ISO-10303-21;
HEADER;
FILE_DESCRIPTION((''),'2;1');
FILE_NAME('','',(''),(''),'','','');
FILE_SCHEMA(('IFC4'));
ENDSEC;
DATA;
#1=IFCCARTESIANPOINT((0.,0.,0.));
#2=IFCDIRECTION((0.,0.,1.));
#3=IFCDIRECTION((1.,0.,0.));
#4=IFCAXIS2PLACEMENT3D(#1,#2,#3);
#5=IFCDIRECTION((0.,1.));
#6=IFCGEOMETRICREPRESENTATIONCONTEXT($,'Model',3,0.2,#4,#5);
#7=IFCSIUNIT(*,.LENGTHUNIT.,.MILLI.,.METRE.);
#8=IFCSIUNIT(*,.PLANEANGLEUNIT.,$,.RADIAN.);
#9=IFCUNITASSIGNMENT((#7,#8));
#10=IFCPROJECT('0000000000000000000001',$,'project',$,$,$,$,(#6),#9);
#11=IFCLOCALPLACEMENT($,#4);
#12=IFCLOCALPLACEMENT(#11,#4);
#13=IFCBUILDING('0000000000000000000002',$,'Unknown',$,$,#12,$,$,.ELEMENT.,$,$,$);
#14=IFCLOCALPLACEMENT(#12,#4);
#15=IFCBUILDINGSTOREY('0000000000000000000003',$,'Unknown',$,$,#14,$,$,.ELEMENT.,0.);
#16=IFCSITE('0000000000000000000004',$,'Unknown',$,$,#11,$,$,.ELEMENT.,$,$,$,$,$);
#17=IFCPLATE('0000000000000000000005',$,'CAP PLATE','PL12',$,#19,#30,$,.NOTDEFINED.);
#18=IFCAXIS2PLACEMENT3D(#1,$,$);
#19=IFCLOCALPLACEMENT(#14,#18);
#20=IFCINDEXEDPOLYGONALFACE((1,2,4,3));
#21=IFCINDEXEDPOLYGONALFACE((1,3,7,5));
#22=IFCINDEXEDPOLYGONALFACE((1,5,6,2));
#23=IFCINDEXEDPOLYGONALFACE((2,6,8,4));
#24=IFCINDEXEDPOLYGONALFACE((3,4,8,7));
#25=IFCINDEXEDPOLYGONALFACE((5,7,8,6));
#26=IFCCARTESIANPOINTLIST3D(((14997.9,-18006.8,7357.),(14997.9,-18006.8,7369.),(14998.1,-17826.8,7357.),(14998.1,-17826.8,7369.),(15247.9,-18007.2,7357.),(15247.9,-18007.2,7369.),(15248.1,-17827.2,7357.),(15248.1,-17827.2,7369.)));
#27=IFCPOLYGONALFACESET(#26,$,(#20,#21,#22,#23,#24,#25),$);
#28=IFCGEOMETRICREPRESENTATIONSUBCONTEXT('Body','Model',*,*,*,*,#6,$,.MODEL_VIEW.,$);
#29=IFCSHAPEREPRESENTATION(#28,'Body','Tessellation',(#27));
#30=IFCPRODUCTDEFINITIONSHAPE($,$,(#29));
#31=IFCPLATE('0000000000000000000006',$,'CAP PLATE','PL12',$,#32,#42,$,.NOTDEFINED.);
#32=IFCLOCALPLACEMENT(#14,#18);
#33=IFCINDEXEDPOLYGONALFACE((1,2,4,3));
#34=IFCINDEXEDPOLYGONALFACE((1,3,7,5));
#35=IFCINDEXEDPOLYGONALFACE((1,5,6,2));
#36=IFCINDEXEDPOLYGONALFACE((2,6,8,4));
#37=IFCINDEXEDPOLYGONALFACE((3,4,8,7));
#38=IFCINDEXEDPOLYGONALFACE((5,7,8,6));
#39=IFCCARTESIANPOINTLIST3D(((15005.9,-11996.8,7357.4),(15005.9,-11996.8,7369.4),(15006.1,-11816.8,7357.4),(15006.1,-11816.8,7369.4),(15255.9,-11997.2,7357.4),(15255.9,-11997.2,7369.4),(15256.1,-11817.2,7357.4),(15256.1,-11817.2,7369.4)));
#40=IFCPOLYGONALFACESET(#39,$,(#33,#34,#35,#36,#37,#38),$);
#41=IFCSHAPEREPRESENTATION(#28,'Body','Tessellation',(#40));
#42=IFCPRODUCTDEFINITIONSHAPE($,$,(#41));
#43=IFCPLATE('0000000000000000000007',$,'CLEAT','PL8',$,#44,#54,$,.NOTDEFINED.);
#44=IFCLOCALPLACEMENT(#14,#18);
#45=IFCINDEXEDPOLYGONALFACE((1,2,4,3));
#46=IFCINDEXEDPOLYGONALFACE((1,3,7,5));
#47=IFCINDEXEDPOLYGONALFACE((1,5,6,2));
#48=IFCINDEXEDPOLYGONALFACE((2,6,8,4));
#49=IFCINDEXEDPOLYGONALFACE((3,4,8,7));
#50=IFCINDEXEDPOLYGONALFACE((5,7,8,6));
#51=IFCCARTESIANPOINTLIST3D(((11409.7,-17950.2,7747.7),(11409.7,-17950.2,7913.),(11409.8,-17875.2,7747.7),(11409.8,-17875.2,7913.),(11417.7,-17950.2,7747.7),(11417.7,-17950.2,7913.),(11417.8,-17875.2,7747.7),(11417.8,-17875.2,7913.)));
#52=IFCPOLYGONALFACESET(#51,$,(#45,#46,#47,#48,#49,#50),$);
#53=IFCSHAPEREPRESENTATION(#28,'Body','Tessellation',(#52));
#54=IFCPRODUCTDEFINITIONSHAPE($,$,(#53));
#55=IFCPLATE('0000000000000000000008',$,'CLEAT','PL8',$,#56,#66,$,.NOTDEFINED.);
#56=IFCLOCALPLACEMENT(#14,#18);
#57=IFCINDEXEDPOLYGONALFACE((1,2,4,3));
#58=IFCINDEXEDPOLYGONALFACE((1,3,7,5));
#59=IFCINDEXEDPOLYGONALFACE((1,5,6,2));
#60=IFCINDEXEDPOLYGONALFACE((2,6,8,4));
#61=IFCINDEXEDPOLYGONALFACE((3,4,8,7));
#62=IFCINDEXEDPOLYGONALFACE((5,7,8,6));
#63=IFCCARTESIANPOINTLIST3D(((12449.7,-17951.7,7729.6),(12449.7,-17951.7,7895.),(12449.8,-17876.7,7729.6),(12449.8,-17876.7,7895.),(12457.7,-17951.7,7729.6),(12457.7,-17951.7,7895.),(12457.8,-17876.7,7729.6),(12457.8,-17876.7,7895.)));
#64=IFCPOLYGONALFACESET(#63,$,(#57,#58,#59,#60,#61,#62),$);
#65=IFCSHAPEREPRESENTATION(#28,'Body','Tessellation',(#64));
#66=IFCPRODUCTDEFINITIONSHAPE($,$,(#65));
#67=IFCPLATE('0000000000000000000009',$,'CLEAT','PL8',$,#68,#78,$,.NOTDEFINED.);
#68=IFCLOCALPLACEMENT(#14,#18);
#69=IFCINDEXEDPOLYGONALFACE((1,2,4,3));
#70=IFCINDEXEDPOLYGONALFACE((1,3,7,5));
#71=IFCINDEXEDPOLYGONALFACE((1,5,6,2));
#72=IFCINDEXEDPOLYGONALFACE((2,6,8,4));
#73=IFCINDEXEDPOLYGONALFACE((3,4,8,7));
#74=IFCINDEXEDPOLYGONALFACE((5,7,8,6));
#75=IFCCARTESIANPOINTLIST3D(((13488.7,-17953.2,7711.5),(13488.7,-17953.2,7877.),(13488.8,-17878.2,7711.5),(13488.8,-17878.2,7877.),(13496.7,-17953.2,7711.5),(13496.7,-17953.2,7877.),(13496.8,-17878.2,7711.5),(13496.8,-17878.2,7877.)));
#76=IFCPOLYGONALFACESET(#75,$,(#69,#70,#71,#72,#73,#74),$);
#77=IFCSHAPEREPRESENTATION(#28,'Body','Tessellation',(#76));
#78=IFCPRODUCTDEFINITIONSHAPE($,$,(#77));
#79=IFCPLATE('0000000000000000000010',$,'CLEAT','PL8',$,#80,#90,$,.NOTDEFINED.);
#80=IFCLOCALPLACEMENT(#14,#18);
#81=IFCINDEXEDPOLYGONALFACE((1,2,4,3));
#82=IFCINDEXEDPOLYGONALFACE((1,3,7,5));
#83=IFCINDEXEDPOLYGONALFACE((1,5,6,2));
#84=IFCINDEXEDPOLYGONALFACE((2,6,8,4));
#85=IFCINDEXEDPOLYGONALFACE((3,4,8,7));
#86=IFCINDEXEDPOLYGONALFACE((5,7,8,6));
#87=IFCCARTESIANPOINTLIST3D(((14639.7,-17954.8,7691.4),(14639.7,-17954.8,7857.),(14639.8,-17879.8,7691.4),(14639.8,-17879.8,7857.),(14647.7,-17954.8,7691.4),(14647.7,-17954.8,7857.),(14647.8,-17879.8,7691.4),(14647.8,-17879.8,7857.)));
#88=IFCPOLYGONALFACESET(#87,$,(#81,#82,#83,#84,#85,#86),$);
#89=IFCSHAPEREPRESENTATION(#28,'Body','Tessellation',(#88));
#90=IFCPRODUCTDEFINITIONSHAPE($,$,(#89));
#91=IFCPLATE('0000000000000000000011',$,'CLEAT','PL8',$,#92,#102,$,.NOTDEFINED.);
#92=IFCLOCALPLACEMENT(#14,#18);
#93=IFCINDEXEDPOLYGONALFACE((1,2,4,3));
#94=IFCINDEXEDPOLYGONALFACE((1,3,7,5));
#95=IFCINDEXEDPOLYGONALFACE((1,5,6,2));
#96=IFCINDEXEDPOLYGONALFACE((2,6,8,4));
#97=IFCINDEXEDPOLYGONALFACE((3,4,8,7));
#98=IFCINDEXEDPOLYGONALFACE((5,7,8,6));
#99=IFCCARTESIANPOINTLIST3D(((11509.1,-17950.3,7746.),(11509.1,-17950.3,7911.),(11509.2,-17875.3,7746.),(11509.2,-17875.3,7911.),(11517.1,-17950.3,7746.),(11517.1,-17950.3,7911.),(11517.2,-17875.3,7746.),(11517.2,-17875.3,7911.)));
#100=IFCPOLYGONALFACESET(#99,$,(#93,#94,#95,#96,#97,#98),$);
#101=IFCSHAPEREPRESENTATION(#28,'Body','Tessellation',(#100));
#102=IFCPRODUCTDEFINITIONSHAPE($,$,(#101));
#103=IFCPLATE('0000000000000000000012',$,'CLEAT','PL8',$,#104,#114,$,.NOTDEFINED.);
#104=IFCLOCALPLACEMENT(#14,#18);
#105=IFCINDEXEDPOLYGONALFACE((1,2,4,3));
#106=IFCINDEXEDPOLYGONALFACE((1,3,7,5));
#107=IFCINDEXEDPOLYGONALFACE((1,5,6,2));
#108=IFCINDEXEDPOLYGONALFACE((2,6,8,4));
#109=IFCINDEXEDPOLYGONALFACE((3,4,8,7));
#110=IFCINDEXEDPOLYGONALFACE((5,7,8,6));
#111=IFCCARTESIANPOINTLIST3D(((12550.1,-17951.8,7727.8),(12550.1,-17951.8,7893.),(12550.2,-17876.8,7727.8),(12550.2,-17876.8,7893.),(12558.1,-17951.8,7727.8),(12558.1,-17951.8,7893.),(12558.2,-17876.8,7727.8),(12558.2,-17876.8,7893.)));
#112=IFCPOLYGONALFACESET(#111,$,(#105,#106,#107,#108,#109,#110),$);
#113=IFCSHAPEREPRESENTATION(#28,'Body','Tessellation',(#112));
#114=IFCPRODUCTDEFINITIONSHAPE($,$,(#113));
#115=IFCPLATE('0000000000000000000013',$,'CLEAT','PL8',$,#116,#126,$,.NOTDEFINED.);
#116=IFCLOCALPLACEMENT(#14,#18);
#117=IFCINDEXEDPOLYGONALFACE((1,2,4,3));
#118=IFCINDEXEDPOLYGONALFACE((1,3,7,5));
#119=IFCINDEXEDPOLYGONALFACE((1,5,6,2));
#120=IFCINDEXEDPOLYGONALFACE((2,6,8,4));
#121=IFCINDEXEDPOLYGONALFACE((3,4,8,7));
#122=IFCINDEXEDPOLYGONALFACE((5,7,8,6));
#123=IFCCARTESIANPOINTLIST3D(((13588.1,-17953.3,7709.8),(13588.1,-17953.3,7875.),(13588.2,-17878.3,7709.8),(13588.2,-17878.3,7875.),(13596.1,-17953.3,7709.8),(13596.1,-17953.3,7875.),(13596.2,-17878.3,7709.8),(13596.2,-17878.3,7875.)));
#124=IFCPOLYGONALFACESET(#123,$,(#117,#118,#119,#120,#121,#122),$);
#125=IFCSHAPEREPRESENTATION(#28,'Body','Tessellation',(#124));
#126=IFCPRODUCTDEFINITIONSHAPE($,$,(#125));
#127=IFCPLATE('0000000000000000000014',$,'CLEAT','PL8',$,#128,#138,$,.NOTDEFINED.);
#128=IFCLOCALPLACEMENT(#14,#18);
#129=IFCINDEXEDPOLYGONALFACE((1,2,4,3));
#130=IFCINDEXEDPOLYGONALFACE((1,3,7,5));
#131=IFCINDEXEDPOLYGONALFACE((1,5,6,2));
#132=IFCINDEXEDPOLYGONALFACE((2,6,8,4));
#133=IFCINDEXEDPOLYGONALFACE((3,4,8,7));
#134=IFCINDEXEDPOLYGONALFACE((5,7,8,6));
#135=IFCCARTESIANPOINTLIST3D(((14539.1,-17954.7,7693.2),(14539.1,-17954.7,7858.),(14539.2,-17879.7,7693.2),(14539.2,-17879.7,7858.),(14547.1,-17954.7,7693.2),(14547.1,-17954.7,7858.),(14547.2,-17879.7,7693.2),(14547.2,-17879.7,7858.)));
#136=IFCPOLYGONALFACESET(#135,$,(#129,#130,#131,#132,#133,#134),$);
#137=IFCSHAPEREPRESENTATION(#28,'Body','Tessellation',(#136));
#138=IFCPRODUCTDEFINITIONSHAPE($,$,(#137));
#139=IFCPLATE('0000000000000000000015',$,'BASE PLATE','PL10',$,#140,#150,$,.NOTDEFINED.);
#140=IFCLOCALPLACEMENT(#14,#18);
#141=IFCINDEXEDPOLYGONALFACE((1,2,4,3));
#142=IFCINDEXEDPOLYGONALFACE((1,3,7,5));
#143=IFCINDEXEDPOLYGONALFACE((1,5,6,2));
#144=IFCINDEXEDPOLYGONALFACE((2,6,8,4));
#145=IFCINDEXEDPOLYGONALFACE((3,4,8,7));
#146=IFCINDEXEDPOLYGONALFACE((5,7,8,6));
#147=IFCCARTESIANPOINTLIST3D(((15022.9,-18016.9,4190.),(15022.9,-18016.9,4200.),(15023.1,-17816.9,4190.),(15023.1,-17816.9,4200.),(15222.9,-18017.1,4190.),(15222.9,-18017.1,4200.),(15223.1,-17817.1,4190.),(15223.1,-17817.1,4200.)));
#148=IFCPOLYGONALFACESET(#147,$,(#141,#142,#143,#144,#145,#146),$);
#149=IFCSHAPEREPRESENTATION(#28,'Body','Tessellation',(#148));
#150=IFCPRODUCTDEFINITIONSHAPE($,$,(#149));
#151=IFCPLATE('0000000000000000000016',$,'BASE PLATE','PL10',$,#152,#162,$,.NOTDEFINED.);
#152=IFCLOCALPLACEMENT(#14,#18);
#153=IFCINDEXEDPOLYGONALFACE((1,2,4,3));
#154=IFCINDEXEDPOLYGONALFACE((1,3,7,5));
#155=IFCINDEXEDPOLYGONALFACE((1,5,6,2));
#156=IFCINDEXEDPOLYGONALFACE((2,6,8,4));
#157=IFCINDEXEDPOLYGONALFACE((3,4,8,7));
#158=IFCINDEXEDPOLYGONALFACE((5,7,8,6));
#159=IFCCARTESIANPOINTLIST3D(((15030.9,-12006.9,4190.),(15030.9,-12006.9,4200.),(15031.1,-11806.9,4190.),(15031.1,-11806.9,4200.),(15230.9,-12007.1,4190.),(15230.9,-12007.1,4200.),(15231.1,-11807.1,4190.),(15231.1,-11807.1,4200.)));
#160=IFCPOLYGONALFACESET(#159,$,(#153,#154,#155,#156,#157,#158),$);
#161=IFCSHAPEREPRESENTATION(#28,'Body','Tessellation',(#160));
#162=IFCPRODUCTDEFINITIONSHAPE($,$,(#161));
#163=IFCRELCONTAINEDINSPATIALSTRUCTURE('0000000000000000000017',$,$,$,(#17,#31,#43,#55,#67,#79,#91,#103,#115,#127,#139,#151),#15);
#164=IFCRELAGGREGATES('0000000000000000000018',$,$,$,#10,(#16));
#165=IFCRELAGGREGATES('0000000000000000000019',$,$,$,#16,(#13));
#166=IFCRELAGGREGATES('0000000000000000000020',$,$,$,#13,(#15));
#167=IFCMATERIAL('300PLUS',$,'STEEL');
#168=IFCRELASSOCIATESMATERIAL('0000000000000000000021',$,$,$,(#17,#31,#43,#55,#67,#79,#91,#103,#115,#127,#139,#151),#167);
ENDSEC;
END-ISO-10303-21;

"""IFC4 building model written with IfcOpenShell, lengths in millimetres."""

from ifc_helpers import new_model, si_unit, direction, frame, origin_with_axes, place, context, subcontext, project, spatial, line, indexed_curve, outline, extrude, material, element, save


model = new_model("IFC4")

# Units and contexts
model_context = context("Model", 3, precision=0.2, world=origin_with_axes(), true_north=direction((0.0, 1.0)))
body_context = subcontext(model_context, "Body", "Model", "MODEL_VIEW")
ifc_project = project(units=[si_unit("LENGTHUNIT", "METRE", prefix="MILLI"), si_unit("PLANEANGLEUNIT", "RADIAN")], contexts=[model_context])

# Site, building, storey
site_placement = place(None, origin_with_axes())
site = spatial("IfcSite", under=ifc_project, at=site_placement, Name="Unknown", CompositionType="ELEMENT")
building_placement = place(site_placement, origin_with_axes())
building = spatial("IfcBuilding", under=site, at=building_placement, Name="Unknown", CompositionType="ELEMENT")
storey_placement = place(building_placement, origin_with_axes())
storey = spatial("IfcBuildingStorey", under=building, at=storey_placement, Name="Unknown", CompositionType="ELEMENT", Elevation=0.0)

# Shared definitions
ifc_material_1 = material(Name="300PLUS", Category="STEEL")

# Plates
for number, where, z_axis, x_axis, name in (
    (1, (14997.9, -18006.8, 7363.0), (0.0, 0.0, 1.0), (0.999999, -0.0016, 0.0), "CAP PLATE"),
    (2, (15005.9, -11996.8, 7363.4), (0.0, 0.0, 1.0), (0.999999, -0.0016, 0.0), "CAP PLATE"),
):
    element("IfcPlate", number, at=place(storey_placement, frame(where, z_axis=z_axis, x_axis=x_axis)), inside=storey, material=ifc_material_1, Name=name, Description="PL12", PredefinedType="NOTDEFINED", context=body_context, shape_type="SolidModel", body=[
        extrude(outline(indexed_curve([(0.0, 0.0), (250.0, 0.0), (249.9, 180.0), (-0.1, 180.0)], segments=[line(1, 2, 3, 4, 1)])), frame((0.0, 0.0, 6.0), z_axis=(0.0, 0.0, 1.0), x_axis=(1.0, 0.0, 0.0)), (0.0, 0.0, -1.0), 12.0),
    ])
plate_1_placement = place(storey_placement, frame((11413.8, -17875.2, 7913.0), z_axis=(0.999999, -0.001333, 0.0), x_axis=(-0.001333, -0.999999, 0.0)))
element("IfcPlate", 3, at=plate_1_placement, inside=storey, material=ifc_material_1, Name="CLEAT", Description="PL8", PredefinedType="NOTDEFINED", context=body_context, shape_type="SolidModel", body=[
    extrude(outline(indexed_curve([(0.0, 0.0), (75.0, 0.0), (75.0, 165.3), (0.0, 165.3)], segments=[line(1, 2, 3, 4, 1)])), frame((0.0, 0.0, 4.0), z_axis=(0.0, 0.0, 1.0), x_axis=(1.0, 0.0, 0.0)), (0.0, 0.0, -1.0), 8.0),
])
plate_2_placement = place(storey_placement, frame((12453.8, -17876.7, 7895.0), z_axis=(0.999999, -0.001333, 0.0), x_axis=(-0.001333, -0.999999, 0.0)))
element("IfcPlate", 4, at=plate_2_placement, inside=storey, material=ifc_material_1, Name="CLEAT", Description="PL8", PredefinedType="NOTDEFINED", context=body_context, shape_type="SolidModel", body=[
    extrude(outline(indexed_curve([(0.0, 0.0), (75.0, 0.0), (75.0, 165.4), (0.0, 165.4)], segments=[line(1, 2, 3, 4, 1)])), frame((0.0, 0.0, 4.0), z_axis=(0.0, 0.0, 1.0), x_axis=(1.0, 0.0, 0.0)), (0.0, 0.0, -1.0), 8.0),
])
plate_3_placement = place(storey_placement, frame((13492.8, -17878.2, 7877.0), z_axis=(0.999999, -0.001333, 0.0), x_axis=(-0.001333, -0.999999, 0.0)))
element("IfcPlate", 5, at=plate_3_placement, inside=storey, material=ifc_material_1, Name="CLEAT", Description="PL8", PredefinedType="NOTDEFINED", context=body_context, shape_type="SolidModel", body=[
    extrude(outline(indexed_curve([(0.0, 0.0), (75.0, 0.0), (75.0, 165.5), (0.0, 165.5)], segments=[line(1, 2, 3, 4, 1)])), frame((0.0, 0.0, 4.0), z_axis=(0.0, 0.0, 1.0), x_axis=(1.0, 0.0, 0.0)), (0.0, 0.0, -1.0), 8.0),
])
plate_4_placement = place(storey_placement, frame((14643.8, -17879.8, 7857.0), z_axis=(0.999999, -0.001333, 0.0), x_axis=(-0.001333, -0.999999, 0.0)))
element("IfcPlate", 6, at=plate_4_placement, inside=storey, material=ifc_material_1, Name="CLEAT", Description="PL8", PredefinedType="NOTDEFINED", context=body_context, shape_type="SolidModel", body=[
    extrude(outline(indexed_curve([(0.0, 0.0), (75.0, 0.0), (75.0, 165.6), (0.0, 165.6)], segments=[line(1, 2, 3, 4, 1)])), frame((0.0, 0.0, 4.0), z_axis=(0.0, 0.0, 1.0), x_axis=(1.0, 0.0, 0.0)), (0.0, 0.0, -1.0), 8.0),
])
plate_5_placement = place(storey_placement, frame((11513.2, -17875.3, 7911.0), z_axis=(0.999999, -0.001333, 0.0), x_axis=(-0.001333, -0.999999, 0.0)))
element("IfcPlate", 7, at=plate_5_placement, inside=storey, material=ifc_material_1, Name="CLEAT", Description="PL8", PredefinedType="NOTDEFINED", context=body_context, shape_type="SolidModel", body=[
    extrude(outline(indexed_curve([(0.0, 0.0), (75.0, 0.0), (75.0, 165.0), (0.0, 165.0)], segments=[line(1, 2, 3, 4, 1)])), frame((0.0, 0.0, 4.0), z_axis=(0.0, 0.0, 1.0), x_axis=(1.0, 0.0, 0.0)), (0.0, 0.0, -1.0), 8.0),
])
for number, where, z_axis, x_axis, name in (
    (8, (12554.2, -17876.8, 7893.0), (0.999999, -0.001333, 0.0), (-0.001333, -0.999999, 0.0), "CLEAT"),
    (9, (13592.2, -17878.3, 7875.0), (0.999999, -0.001333, 0.0), (-0.001333, -0.999999, 0.0), "CLEAT"),
):
    element("IfcPlate", number, at=place(storey_placement, frame(where, z_axis=z_axis, x_axis=x_axis)), inside=storey, material=ifc_material_1, Name=name, Description="PL8", PredefinedType="NOTDEFINED", context=body_context, shape_type="SolidModel", body=[
        extrude(outline(indexed_curve([(0.0, 0.0), (75.0, 0.0), (75.0, 165.2), (0.0, 165.2)], segments=[line(1, 2, 3, 4, 1)])), frame((0.0, 0.0, 4.0), z_axis=(0.0, 0.0, 1.0), x_axis=(1.0, 0.0, 0.0)), (0.0, 0.0, -1.0), 8.0),
    ])
plate_6_placement = place(storey_placement, frame((14543.2, -17879.7, 7858.0), z_axis=(0.999999, -0.001333, 0.0), x_axis=(-0.001333, -0.999999, 0.0)))
element("IfcPlate", 10, at=plate_6_placement, inside=storey, material=ifc_material_1, Name="CLEAT", Description="PL8", PredefinedType="NOTDEFINED", context=body_context, shape_type="SolidModel", body=[
    extrude(outline(indexed_curve([(0.0, 0.0), (75.0, 0.0), (75.0, 164.8), (0.0, 164.8)], segments=[line(1, 2, 3, 4, 1)])), frame((0.0, 0.0, 4.0), z_axis=(0.0, 0.0, 1.0), x_axis=(1.0, 0.0, 0.0)), (0.0, 0.0, -1.0), 8.0),
])
for number, where, z_axis, x_axis, name in (
    (11, (15022.9, -18016.9, 4195.0), (0.0, 0.0, 1.0), (1.0, -0.001, 0.0), "BASE PLATE"),
    (12, (15030.9, -12006.9, 4195.0), (0.0, 0.0, 1.0), (1.0, -0.001, 0.0), "BASE PLATE"),
):
    element("IfcPlate", number, at=place(storey_placement, frame(where, z_axis=z_axis, x_axis=x_axis)), inside=storey, material=ifc_material_1, Name=name, Description="PL10", PredefinedType="NOTDEFINED", context=body_context, shape_type="SolidModel", body=[
        extrude(outline(indexed_curve([(0.0, 0.0), (200.0, 0.0), (200.0, 200.0), (0.0, 200.0)], segments=[line(1, 2, 3, 4, 1)])), frame((0.0, 0.0, 5.0), z_axis=(0.0, 0.0, 1.0), x_axis=(1.0, 0.0, 0.0)), (0.0, 0.0, -1.0), 10.0),
    ])

save(model, "model.ifc")
